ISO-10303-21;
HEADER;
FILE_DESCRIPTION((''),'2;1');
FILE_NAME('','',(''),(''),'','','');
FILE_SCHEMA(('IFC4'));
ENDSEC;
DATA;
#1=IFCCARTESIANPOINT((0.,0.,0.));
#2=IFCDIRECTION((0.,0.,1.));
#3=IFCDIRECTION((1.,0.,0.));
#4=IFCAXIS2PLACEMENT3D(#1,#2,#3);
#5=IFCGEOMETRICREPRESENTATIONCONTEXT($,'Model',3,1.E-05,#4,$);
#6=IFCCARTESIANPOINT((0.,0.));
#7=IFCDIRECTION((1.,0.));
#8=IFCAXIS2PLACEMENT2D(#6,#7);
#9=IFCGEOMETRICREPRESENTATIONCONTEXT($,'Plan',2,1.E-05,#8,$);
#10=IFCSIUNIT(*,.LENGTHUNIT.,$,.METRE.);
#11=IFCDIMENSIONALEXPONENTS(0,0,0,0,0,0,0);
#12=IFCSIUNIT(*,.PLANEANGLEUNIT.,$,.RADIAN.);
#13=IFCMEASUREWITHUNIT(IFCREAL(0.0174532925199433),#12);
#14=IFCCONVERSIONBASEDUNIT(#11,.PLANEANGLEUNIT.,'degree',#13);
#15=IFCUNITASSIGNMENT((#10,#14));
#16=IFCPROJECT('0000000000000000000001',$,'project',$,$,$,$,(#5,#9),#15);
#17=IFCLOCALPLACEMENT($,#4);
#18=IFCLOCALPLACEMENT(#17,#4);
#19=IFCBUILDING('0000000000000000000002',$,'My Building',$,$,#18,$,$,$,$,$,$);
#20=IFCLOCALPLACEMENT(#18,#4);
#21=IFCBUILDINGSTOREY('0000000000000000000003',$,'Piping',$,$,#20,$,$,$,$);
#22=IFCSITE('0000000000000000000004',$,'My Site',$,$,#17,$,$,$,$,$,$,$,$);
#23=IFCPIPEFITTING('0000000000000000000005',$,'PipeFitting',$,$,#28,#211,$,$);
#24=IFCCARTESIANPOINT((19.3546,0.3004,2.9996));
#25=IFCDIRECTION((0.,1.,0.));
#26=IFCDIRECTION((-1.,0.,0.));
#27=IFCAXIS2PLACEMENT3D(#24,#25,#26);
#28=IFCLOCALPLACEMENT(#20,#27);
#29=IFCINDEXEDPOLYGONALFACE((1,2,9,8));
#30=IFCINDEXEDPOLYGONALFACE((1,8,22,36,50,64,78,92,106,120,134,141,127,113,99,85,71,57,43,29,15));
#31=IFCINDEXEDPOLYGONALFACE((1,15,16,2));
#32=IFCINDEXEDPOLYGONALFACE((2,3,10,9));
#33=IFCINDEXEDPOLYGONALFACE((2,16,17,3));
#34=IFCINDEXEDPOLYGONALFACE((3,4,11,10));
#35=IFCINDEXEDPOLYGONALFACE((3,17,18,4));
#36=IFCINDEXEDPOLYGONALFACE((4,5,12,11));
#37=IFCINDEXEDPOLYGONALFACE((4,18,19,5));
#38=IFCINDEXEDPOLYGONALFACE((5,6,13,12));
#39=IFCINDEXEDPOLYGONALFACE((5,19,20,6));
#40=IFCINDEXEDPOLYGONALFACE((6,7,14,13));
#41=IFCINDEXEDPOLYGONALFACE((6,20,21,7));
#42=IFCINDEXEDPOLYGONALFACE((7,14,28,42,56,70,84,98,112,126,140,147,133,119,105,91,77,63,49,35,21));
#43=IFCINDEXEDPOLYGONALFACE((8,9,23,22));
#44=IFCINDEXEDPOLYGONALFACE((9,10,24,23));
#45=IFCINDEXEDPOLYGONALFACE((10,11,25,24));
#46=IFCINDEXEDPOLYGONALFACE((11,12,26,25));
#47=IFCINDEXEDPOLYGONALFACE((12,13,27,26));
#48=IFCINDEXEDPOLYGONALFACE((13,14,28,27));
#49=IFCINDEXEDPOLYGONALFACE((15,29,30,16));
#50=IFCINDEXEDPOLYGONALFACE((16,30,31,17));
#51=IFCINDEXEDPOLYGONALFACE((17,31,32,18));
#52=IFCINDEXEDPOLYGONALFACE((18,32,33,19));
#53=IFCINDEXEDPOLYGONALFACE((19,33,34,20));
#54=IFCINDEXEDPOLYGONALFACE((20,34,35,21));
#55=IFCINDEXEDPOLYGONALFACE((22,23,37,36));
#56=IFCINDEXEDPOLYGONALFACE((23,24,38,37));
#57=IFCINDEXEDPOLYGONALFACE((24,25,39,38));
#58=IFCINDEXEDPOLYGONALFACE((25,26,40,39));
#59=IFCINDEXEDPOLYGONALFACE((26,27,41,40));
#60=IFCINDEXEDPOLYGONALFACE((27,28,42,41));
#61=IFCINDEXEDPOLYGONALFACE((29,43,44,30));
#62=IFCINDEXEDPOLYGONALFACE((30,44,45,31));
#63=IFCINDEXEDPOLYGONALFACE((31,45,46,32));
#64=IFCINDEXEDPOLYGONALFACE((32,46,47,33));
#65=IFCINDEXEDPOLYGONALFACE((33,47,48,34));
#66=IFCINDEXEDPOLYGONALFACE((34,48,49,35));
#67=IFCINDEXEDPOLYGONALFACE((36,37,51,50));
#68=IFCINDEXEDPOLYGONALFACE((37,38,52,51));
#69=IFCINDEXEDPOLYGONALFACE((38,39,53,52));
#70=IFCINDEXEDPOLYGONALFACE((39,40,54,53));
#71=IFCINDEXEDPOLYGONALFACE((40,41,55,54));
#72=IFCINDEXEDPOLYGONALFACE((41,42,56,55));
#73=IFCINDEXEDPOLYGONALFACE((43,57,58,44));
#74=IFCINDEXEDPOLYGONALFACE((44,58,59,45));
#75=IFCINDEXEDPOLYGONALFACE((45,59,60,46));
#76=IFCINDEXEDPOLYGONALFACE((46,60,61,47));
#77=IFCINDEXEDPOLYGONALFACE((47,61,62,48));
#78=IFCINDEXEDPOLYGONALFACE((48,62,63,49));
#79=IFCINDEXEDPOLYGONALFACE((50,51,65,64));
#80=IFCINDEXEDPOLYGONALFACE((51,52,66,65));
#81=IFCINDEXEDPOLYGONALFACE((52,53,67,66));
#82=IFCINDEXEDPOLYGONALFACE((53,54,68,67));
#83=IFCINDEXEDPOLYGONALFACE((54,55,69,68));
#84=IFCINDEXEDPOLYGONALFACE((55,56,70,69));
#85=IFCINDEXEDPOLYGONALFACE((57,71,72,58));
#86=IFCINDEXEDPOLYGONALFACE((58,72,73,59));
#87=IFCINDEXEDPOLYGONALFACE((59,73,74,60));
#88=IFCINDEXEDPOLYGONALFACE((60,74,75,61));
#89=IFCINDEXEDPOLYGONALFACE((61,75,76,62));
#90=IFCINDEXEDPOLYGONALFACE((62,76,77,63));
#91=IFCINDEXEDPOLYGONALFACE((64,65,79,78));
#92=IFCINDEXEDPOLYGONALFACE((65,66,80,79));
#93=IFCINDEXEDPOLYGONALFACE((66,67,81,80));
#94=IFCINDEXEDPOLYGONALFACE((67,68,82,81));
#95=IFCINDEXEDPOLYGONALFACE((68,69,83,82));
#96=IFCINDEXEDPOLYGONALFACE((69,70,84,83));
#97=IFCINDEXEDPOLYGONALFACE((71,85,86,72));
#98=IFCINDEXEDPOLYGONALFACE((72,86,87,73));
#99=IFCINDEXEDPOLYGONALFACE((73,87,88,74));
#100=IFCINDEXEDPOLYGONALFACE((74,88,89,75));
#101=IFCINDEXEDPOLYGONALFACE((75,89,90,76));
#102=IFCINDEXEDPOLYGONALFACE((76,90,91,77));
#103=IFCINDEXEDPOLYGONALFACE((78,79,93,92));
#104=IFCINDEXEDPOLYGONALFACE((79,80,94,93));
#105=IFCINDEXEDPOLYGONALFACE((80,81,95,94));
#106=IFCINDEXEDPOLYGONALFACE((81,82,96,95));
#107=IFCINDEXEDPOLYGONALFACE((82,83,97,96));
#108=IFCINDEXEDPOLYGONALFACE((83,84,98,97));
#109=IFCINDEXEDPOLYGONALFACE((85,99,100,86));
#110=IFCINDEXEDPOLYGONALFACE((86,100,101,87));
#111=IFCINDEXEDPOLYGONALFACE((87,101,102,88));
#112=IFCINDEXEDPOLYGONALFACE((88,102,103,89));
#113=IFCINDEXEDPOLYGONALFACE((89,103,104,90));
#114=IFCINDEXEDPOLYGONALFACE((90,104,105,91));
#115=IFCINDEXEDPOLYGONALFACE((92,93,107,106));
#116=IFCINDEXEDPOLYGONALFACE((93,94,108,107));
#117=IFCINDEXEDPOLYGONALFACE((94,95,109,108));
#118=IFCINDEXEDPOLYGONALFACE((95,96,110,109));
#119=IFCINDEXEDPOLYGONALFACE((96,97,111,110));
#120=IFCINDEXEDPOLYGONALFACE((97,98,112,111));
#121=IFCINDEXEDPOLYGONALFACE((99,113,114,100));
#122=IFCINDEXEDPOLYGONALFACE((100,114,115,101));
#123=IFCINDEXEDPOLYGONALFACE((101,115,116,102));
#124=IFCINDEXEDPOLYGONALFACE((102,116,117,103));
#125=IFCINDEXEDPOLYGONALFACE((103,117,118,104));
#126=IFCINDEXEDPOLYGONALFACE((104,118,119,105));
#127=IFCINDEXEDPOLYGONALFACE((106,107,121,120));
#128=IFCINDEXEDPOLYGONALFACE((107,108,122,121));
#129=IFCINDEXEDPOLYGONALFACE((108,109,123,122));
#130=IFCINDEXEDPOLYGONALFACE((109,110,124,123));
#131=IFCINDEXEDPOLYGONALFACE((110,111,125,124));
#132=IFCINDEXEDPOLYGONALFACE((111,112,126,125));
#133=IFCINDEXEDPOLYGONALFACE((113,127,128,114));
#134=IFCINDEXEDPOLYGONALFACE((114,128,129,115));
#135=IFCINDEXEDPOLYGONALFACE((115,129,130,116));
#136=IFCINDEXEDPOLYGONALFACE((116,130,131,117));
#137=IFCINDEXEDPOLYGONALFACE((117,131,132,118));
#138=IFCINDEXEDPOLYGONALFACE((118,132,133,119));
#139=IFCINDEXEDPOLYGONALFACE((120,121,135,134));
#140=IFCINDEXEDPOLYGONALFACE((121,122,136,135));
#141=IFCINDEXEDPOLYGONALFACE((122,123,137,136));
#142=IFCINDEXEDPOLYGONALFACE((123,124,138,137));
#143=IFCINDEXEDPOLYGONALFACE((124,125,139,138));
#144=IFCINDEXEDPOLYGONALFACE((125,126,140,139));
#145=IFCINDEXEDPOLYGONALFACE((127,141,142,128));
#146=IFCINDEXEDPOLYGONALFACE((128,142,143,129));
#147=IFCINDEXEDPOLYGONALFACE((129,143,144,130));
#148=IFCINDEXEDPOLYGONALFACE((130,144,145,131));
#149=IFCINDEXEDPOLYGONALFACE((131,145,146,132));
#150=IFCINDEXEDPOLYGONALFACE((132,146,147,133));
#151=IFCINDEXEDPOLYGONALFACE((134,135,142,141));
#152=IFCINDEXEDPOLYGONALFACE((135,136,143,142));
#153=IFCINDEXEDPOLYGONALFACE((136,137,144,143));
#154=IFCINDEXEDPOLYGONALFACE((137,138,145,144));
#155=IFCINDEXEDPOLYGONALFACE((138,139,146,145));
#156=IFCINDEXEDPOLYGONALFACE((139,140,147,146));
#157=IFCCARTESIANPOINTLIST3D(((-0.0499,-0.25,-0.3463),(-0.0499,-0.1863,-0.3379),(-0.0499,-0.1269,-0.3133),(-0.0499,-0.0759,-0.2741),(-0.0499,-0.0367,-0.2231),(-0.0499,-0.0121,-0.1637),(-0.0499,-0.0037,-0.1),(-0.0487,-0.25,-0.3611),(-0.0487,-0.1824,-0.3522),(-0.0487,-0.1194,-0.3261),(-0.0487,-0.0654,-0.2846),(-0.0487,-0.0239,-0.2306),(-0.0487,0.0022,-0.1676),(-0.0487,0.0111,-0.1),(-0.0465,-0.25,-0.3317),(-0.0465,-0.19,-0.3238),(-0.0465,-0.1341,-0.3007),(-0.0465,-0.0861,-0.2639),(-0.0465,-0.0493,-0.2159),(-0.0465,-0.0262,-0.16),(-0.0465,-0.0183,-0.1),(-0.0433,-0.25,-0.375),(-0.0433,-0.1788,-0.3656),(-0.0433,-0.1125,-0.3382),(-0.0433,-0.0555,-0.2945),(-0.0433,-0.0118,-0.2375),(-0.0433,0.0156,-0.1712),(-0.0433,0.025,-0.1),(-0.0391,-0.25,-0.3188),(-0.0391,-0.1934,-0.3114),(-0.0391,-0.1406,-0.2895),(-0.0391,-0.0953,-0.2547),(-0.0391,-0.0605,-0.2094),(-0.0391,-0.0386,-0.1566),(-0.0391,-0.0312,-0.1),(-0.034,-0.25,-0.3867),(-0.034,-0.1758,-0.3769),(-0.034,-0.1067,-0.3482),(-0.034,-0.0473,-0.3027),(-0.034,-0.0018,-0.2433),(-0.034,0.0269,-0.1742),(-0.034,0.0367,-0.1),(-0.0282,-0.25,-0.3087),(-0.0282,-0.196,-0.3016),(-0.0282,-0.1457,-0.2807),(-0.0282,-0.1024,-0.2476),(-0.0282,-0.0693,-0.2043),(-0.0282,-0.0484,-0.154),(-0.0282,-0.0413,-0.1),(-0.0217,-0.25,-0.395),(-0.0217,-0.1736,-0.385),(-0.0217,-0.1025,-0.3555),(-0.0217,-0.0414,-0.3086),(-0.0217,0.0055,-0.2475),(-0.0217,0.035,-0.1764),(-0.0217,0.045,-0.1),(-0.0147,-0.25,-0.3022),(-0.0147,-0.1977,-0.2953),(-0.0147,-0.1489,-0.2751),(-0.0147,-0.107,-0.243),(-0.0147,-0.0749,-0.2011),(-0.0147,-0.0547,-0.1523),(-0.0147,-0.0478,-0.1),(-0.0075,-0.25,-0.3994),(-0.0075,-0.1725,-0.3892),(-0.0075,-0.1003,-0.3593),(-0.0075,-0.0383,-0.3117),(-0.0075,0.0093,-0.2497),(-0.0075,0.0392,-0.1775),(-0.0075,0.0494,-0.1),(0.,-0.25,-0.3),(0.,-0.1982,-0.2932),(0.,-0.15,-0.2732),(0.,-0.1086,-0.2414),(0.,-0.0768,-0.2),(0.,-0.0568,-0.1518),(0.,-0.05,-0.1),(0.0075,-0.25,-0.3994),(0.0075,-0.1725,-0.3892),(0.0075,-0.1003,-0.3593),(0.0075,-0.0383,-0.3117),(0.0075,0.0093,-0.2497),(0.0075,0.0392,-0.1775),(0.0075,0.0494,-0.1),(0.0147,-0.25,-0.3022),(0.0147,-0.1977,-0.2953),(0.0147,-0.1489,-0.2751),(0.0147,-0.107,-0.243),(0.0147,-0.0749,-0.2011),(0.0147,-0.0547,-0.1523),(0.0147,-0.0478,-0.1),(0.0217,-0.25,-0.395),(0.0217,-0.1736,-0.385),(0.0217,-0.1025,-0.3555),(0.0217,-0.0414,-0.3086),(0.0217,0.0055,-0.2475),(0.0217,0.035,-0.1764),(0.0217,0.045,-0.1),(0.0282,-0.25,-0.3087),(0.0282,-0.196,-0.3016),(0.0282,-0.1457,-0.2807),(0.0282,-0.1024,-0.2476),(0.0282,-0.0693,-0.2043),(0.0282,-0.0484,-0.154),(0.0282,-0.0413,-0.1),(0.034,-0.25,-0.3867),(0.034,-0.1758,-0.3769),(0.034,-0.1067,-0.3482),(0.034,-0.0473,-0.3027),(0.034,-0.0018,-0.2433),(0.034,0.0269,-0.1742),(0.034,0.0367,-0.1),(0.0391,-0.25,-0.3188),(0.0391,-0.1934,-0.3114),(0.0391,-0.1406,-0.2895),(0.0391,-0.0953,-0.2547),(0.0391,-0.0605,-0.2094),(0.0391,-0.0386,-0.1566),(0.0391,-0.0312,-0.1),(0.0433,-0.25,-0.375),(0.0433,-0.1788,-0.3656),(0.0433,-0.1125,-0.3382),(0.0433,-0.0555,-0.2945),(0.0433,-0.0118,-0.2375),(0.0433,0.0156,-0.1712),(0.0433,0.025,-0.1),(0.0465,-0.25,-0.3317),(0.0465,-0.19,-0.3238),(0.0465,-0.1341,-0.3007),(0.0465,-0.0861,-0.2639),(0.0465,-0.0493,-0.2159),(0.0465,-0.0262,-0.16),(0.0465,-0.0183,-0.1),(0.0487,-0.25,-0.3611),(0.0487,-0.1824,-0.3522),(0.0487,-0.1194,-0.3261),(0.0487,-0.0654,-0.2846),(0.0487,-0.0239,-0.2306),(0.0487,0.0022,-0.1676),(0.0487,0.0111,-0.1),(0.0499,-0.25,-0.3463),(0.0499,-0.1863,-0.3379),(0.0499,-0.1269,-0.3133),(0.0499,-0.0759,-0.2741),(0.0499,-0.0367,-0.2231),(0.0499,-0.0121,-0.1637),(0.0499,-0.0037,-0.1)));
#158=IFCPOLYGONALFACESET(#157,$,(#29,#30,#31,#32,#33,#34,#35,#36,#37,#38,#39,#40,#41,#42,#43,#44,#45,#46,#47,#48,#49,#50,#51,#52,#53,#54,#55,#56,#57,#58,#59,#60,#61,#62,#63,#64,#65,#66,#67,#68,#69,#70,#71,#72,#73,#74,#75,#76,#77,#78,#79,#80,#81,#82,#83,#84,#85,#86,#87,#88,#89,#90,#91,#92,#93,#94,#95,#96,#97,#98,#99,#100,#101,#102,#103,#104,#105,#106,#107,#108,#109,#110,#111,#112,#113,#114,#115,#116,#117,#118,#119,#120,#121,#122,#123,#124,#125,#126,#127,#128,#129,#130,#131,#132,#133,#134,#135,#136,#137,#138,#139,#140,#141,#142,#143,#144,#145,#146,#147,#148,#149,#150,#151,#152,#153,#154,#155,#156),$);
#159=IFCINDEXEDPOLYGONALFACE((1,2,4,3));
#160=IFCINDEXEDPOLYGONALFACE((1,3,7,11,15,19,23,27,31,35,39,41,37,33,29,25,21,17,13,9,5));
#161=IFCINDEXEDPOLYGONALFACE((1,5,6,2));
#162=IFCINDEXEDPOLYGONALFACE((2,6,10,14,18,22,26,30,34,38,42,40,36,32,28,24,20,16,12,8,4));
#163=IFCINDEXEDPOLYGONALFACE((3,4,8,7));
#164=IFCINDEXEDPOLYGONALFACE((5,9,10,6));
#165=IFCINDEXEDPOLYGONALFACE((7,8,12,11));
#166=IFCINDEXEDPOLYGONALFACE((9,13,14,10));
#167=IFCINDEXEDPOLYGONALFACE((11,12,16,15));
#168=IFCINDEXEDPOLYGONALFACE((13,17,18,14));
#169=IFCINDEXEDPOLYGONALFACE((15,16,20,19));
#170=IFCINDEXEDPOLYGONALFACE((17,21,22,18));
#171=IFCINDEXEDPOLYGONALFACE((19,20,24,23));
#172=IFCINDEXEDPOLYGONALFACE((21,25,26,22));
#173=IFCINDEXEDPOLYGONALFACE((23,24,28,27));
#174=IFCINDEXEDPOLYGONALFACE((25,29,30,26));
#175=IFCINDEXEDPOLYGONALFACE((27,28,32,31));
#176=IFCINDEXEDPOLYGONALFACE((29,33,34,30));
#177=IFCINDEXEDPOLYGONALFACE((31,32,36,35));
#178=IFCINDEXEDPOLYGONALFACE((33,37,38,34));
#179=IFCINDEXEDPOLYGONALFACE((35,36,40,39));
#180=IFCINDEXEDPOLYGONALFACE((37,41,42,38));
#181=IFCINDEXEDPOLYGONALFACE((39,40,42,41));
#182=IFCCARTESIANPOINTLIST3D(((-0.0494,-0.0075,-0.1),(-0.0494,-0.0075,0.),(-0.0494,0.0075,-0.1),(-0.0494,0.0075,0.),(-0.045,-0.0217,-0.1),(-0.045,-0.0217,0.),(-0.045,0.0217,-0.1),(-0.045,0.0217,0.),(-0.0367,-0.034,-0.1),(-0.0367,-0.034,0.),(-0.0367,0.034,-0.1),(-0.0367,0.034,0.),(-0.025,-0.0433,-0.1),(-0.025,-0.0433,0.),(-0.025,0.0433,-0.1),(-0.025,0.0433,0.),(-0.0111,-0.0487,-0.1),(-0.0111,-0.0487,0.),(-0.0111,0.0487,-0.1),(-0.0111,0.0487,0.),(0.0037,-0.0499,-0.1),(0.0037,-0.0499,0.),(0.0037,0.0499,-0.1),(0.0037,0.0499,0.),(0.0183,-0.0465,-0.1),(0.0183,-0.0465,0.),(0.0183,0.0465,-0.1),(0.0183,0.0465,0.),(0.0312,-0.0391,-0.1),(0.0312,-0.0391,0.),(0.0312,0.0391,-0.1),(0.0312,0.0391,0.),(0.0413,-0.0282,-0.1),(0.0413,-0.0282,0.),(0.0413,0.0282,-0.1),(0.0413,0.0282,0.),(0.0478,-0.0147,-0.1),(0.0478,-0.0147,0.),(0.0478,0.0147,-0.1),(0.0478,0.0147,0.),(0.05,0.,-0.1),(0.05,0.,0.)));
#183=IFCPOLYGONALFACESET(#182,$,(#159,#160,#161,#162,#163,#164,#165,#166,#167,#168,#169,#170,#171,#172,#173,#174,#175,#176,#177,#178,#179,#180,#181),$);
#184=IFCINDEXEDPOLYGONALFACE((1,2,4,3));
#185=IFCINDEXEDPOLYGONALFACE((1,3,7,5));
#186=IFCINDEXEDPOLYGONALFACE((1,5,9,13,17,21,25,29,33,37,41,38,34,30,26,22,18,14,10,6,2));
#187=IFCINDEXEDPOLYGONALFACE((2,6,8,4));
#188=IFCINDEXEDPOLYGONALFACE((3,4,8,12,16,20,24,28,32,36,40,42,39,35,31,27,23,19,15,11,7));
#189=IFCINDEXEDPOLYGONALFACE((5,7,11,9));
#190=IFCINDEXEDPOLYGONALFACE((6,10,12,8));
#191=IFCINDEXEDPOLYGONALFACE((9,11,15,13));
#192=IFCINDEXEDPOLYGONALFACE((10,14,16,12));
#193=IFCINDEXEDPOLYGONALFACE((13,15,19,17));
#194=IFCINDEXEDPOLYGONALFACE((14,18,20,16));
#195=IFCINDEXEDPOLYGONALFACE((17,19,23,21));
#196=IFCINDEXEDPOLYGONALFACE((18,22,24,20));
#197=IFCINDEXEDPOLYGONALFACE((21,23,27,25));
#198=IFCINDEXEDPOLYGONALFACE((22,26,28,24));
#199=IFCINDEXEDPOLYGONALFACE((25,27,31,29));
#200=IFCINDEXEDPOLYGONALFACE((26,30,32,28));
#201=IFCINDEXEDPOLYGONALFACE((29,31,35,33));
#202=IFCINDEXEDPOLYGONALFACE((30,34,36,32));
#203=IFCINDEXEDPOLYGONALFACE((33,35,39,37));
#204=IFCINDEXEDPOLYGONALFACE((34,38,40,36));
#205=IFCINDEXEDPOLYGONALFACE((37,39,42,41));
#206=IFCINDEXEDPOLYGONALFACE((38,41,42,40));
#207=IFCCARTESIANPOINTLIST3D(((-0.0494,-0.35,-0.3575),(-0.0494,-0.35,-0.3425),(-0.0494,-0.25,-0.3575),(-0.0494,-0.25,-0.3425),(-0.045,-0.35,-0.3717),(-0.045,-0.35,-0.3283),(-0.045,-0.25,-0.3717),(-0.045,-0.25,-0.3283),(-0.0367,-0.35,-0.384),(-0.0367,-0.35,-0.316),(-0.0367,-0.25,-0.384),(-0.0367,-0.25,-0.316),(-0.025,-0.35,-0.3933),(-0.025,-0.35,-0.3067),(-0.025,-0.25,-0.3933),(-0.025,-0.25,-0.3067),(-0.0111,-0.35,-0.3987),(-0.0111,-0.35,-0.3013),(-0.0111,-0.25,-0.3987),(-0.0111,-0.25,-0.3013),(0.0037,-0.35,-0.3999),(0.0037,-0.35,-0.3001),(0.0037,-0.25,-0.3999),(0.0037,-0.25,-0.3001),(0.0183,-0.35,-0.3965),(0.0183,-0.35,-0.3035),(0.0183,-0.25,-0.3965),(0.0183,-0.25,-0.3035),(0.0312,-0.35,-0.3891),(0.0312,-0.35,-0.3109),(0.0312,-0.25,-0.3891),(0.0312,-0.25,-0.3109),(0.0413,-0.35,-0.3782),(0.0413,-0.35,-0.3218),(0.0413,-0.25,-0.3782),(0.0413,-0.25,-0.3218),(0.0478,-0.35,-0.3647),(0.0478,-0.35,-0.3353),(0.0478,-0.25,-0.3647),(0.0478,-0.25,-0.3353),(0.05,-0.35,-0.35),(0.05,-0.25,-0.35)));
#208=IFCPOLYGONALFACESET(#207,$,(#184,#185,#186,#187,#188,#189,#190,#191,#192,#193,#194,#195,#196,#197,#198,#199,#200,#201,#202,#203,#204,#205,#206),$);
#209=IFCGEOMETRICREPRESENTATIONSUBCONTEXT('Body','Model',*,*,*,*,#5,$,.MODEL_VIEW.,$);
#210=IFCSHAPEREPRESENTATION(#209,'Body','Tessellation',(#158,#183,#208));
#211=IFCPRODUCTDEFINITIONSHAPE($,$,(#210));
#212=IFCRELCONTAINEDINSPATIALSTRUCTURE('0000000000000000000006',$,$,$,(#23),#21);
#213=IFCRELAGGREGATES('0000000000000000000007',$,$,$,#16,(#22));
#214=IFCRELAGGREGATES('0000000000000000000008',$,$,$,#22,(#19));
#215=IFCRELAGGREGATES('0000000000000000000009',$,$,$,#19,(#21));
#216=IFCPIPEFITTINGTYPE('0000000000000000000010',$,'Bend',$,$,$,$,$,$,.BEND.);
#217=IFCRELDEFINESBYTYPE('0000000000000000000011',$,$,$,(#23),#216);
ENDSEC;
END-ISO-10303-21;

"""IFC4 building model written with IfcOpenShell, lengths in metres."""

from ifc_helpers import new_model, entity, si_unit, converted_unit, frame, origin_with_axes, origin_2d_with_axis, place, context, subcontext, project, spatial, circle, extrude, source, transform, mapped, type_object, type_shapes, element, save


model = new_model("IFC4")

# Units and contexts
model_context = context("Model", 3, precision=1e-05, world=origin_with_axes())
plan_context = context("Plan", 2, precision=1e-05, world=origin_2d_with_axis())
body_context = subcontext(model_context, "Body", "Model", "MODEL_VIEW")
ifc_project = project(units=[si_unit("LENGTHUNIT", "METRE"), converted_unit("PLANEANGLEUNIT", "degree", entity("IfcReal", 0.0174532925199433), si_unit("PLANEANGLEUNIT", "RADIAN"), dimensions=[0, 0, 0, 0, 0, 0, 0])], contexts=[model_context, plan_context])

# Site, building, storey
site_placement = place(None, origin_with_axes())
site = spatial("IfcSite", under=ifc_project, at=site_placement, Name="My Site")
building_placement = place(site_placement, origin_with_axes())
building = spatial("IfcBuilding", under=site, at=building_placement, Name="My Building")
storey_placement = place(building_placement, origin_with_axes())
storey = spatial("IfcBuildingStorey", under=building, at=storey_placement, Name="Piping")

# Pipe fitting
pipe_fitting_type = type_object("IfcPipeFittingType", Name="Bend", PredefinedType="BEND")
shared_shape = source(origin_with_axes(), body_context, "Body", "SolidModel", [
    entity("IfcSweptDiskSolid", entity("IfcIndexedPolyCurve", entity("IfcCartesianPointList3D", [[0.0, 0.0, -0.1], [0.0, -0.0732, -0.2768], [0.0, -0.25, -0.35]]), [entity("IfcArcIndex", [1, 2, 3])]), 0.05),
    extrude(circle(Radius=0.05), origin_with_axes(), (0.0, 0.0, -1.0), 0.1),
    extrude(circle(Radius=0.05), frame((0.0, -0.25, -0.35), z_axis=(0.0, -1.0, 0.0), x_axis=(1.0, 0.0, 0.0)), (0.0, 0.0, 1.0), 0.1),
])
type_shapes(pipe_fitting_type, [shared_shape])
for number, where, z_axis, x_axis, name in (
    (1, (19.3546, 0.3004, 2.9996), (0.0, 1.0, 0.0), (-1.0, 0.0, 0.0), "PipeFitting"),
):
    element("IfcPipeFitting", number, at=place(storey_placement, frame(where, z_axis=z_axis, x_axis=x_axis)), inside=storey, type_object=pipe_fitting_type, Name=name, context=body_context, shape_type="MappedRepresentation", body=[
        mapped(shared_shape, transform((0.0, 0.0, 0.0), x_axis=(1.0, 0.0, 0.0), y_axis=(0.0, 1.0, 0.0), z_axis=(0.0, 0.0, 1.0), scale=1.0)),
    ])

save(model, "model.ifc")
